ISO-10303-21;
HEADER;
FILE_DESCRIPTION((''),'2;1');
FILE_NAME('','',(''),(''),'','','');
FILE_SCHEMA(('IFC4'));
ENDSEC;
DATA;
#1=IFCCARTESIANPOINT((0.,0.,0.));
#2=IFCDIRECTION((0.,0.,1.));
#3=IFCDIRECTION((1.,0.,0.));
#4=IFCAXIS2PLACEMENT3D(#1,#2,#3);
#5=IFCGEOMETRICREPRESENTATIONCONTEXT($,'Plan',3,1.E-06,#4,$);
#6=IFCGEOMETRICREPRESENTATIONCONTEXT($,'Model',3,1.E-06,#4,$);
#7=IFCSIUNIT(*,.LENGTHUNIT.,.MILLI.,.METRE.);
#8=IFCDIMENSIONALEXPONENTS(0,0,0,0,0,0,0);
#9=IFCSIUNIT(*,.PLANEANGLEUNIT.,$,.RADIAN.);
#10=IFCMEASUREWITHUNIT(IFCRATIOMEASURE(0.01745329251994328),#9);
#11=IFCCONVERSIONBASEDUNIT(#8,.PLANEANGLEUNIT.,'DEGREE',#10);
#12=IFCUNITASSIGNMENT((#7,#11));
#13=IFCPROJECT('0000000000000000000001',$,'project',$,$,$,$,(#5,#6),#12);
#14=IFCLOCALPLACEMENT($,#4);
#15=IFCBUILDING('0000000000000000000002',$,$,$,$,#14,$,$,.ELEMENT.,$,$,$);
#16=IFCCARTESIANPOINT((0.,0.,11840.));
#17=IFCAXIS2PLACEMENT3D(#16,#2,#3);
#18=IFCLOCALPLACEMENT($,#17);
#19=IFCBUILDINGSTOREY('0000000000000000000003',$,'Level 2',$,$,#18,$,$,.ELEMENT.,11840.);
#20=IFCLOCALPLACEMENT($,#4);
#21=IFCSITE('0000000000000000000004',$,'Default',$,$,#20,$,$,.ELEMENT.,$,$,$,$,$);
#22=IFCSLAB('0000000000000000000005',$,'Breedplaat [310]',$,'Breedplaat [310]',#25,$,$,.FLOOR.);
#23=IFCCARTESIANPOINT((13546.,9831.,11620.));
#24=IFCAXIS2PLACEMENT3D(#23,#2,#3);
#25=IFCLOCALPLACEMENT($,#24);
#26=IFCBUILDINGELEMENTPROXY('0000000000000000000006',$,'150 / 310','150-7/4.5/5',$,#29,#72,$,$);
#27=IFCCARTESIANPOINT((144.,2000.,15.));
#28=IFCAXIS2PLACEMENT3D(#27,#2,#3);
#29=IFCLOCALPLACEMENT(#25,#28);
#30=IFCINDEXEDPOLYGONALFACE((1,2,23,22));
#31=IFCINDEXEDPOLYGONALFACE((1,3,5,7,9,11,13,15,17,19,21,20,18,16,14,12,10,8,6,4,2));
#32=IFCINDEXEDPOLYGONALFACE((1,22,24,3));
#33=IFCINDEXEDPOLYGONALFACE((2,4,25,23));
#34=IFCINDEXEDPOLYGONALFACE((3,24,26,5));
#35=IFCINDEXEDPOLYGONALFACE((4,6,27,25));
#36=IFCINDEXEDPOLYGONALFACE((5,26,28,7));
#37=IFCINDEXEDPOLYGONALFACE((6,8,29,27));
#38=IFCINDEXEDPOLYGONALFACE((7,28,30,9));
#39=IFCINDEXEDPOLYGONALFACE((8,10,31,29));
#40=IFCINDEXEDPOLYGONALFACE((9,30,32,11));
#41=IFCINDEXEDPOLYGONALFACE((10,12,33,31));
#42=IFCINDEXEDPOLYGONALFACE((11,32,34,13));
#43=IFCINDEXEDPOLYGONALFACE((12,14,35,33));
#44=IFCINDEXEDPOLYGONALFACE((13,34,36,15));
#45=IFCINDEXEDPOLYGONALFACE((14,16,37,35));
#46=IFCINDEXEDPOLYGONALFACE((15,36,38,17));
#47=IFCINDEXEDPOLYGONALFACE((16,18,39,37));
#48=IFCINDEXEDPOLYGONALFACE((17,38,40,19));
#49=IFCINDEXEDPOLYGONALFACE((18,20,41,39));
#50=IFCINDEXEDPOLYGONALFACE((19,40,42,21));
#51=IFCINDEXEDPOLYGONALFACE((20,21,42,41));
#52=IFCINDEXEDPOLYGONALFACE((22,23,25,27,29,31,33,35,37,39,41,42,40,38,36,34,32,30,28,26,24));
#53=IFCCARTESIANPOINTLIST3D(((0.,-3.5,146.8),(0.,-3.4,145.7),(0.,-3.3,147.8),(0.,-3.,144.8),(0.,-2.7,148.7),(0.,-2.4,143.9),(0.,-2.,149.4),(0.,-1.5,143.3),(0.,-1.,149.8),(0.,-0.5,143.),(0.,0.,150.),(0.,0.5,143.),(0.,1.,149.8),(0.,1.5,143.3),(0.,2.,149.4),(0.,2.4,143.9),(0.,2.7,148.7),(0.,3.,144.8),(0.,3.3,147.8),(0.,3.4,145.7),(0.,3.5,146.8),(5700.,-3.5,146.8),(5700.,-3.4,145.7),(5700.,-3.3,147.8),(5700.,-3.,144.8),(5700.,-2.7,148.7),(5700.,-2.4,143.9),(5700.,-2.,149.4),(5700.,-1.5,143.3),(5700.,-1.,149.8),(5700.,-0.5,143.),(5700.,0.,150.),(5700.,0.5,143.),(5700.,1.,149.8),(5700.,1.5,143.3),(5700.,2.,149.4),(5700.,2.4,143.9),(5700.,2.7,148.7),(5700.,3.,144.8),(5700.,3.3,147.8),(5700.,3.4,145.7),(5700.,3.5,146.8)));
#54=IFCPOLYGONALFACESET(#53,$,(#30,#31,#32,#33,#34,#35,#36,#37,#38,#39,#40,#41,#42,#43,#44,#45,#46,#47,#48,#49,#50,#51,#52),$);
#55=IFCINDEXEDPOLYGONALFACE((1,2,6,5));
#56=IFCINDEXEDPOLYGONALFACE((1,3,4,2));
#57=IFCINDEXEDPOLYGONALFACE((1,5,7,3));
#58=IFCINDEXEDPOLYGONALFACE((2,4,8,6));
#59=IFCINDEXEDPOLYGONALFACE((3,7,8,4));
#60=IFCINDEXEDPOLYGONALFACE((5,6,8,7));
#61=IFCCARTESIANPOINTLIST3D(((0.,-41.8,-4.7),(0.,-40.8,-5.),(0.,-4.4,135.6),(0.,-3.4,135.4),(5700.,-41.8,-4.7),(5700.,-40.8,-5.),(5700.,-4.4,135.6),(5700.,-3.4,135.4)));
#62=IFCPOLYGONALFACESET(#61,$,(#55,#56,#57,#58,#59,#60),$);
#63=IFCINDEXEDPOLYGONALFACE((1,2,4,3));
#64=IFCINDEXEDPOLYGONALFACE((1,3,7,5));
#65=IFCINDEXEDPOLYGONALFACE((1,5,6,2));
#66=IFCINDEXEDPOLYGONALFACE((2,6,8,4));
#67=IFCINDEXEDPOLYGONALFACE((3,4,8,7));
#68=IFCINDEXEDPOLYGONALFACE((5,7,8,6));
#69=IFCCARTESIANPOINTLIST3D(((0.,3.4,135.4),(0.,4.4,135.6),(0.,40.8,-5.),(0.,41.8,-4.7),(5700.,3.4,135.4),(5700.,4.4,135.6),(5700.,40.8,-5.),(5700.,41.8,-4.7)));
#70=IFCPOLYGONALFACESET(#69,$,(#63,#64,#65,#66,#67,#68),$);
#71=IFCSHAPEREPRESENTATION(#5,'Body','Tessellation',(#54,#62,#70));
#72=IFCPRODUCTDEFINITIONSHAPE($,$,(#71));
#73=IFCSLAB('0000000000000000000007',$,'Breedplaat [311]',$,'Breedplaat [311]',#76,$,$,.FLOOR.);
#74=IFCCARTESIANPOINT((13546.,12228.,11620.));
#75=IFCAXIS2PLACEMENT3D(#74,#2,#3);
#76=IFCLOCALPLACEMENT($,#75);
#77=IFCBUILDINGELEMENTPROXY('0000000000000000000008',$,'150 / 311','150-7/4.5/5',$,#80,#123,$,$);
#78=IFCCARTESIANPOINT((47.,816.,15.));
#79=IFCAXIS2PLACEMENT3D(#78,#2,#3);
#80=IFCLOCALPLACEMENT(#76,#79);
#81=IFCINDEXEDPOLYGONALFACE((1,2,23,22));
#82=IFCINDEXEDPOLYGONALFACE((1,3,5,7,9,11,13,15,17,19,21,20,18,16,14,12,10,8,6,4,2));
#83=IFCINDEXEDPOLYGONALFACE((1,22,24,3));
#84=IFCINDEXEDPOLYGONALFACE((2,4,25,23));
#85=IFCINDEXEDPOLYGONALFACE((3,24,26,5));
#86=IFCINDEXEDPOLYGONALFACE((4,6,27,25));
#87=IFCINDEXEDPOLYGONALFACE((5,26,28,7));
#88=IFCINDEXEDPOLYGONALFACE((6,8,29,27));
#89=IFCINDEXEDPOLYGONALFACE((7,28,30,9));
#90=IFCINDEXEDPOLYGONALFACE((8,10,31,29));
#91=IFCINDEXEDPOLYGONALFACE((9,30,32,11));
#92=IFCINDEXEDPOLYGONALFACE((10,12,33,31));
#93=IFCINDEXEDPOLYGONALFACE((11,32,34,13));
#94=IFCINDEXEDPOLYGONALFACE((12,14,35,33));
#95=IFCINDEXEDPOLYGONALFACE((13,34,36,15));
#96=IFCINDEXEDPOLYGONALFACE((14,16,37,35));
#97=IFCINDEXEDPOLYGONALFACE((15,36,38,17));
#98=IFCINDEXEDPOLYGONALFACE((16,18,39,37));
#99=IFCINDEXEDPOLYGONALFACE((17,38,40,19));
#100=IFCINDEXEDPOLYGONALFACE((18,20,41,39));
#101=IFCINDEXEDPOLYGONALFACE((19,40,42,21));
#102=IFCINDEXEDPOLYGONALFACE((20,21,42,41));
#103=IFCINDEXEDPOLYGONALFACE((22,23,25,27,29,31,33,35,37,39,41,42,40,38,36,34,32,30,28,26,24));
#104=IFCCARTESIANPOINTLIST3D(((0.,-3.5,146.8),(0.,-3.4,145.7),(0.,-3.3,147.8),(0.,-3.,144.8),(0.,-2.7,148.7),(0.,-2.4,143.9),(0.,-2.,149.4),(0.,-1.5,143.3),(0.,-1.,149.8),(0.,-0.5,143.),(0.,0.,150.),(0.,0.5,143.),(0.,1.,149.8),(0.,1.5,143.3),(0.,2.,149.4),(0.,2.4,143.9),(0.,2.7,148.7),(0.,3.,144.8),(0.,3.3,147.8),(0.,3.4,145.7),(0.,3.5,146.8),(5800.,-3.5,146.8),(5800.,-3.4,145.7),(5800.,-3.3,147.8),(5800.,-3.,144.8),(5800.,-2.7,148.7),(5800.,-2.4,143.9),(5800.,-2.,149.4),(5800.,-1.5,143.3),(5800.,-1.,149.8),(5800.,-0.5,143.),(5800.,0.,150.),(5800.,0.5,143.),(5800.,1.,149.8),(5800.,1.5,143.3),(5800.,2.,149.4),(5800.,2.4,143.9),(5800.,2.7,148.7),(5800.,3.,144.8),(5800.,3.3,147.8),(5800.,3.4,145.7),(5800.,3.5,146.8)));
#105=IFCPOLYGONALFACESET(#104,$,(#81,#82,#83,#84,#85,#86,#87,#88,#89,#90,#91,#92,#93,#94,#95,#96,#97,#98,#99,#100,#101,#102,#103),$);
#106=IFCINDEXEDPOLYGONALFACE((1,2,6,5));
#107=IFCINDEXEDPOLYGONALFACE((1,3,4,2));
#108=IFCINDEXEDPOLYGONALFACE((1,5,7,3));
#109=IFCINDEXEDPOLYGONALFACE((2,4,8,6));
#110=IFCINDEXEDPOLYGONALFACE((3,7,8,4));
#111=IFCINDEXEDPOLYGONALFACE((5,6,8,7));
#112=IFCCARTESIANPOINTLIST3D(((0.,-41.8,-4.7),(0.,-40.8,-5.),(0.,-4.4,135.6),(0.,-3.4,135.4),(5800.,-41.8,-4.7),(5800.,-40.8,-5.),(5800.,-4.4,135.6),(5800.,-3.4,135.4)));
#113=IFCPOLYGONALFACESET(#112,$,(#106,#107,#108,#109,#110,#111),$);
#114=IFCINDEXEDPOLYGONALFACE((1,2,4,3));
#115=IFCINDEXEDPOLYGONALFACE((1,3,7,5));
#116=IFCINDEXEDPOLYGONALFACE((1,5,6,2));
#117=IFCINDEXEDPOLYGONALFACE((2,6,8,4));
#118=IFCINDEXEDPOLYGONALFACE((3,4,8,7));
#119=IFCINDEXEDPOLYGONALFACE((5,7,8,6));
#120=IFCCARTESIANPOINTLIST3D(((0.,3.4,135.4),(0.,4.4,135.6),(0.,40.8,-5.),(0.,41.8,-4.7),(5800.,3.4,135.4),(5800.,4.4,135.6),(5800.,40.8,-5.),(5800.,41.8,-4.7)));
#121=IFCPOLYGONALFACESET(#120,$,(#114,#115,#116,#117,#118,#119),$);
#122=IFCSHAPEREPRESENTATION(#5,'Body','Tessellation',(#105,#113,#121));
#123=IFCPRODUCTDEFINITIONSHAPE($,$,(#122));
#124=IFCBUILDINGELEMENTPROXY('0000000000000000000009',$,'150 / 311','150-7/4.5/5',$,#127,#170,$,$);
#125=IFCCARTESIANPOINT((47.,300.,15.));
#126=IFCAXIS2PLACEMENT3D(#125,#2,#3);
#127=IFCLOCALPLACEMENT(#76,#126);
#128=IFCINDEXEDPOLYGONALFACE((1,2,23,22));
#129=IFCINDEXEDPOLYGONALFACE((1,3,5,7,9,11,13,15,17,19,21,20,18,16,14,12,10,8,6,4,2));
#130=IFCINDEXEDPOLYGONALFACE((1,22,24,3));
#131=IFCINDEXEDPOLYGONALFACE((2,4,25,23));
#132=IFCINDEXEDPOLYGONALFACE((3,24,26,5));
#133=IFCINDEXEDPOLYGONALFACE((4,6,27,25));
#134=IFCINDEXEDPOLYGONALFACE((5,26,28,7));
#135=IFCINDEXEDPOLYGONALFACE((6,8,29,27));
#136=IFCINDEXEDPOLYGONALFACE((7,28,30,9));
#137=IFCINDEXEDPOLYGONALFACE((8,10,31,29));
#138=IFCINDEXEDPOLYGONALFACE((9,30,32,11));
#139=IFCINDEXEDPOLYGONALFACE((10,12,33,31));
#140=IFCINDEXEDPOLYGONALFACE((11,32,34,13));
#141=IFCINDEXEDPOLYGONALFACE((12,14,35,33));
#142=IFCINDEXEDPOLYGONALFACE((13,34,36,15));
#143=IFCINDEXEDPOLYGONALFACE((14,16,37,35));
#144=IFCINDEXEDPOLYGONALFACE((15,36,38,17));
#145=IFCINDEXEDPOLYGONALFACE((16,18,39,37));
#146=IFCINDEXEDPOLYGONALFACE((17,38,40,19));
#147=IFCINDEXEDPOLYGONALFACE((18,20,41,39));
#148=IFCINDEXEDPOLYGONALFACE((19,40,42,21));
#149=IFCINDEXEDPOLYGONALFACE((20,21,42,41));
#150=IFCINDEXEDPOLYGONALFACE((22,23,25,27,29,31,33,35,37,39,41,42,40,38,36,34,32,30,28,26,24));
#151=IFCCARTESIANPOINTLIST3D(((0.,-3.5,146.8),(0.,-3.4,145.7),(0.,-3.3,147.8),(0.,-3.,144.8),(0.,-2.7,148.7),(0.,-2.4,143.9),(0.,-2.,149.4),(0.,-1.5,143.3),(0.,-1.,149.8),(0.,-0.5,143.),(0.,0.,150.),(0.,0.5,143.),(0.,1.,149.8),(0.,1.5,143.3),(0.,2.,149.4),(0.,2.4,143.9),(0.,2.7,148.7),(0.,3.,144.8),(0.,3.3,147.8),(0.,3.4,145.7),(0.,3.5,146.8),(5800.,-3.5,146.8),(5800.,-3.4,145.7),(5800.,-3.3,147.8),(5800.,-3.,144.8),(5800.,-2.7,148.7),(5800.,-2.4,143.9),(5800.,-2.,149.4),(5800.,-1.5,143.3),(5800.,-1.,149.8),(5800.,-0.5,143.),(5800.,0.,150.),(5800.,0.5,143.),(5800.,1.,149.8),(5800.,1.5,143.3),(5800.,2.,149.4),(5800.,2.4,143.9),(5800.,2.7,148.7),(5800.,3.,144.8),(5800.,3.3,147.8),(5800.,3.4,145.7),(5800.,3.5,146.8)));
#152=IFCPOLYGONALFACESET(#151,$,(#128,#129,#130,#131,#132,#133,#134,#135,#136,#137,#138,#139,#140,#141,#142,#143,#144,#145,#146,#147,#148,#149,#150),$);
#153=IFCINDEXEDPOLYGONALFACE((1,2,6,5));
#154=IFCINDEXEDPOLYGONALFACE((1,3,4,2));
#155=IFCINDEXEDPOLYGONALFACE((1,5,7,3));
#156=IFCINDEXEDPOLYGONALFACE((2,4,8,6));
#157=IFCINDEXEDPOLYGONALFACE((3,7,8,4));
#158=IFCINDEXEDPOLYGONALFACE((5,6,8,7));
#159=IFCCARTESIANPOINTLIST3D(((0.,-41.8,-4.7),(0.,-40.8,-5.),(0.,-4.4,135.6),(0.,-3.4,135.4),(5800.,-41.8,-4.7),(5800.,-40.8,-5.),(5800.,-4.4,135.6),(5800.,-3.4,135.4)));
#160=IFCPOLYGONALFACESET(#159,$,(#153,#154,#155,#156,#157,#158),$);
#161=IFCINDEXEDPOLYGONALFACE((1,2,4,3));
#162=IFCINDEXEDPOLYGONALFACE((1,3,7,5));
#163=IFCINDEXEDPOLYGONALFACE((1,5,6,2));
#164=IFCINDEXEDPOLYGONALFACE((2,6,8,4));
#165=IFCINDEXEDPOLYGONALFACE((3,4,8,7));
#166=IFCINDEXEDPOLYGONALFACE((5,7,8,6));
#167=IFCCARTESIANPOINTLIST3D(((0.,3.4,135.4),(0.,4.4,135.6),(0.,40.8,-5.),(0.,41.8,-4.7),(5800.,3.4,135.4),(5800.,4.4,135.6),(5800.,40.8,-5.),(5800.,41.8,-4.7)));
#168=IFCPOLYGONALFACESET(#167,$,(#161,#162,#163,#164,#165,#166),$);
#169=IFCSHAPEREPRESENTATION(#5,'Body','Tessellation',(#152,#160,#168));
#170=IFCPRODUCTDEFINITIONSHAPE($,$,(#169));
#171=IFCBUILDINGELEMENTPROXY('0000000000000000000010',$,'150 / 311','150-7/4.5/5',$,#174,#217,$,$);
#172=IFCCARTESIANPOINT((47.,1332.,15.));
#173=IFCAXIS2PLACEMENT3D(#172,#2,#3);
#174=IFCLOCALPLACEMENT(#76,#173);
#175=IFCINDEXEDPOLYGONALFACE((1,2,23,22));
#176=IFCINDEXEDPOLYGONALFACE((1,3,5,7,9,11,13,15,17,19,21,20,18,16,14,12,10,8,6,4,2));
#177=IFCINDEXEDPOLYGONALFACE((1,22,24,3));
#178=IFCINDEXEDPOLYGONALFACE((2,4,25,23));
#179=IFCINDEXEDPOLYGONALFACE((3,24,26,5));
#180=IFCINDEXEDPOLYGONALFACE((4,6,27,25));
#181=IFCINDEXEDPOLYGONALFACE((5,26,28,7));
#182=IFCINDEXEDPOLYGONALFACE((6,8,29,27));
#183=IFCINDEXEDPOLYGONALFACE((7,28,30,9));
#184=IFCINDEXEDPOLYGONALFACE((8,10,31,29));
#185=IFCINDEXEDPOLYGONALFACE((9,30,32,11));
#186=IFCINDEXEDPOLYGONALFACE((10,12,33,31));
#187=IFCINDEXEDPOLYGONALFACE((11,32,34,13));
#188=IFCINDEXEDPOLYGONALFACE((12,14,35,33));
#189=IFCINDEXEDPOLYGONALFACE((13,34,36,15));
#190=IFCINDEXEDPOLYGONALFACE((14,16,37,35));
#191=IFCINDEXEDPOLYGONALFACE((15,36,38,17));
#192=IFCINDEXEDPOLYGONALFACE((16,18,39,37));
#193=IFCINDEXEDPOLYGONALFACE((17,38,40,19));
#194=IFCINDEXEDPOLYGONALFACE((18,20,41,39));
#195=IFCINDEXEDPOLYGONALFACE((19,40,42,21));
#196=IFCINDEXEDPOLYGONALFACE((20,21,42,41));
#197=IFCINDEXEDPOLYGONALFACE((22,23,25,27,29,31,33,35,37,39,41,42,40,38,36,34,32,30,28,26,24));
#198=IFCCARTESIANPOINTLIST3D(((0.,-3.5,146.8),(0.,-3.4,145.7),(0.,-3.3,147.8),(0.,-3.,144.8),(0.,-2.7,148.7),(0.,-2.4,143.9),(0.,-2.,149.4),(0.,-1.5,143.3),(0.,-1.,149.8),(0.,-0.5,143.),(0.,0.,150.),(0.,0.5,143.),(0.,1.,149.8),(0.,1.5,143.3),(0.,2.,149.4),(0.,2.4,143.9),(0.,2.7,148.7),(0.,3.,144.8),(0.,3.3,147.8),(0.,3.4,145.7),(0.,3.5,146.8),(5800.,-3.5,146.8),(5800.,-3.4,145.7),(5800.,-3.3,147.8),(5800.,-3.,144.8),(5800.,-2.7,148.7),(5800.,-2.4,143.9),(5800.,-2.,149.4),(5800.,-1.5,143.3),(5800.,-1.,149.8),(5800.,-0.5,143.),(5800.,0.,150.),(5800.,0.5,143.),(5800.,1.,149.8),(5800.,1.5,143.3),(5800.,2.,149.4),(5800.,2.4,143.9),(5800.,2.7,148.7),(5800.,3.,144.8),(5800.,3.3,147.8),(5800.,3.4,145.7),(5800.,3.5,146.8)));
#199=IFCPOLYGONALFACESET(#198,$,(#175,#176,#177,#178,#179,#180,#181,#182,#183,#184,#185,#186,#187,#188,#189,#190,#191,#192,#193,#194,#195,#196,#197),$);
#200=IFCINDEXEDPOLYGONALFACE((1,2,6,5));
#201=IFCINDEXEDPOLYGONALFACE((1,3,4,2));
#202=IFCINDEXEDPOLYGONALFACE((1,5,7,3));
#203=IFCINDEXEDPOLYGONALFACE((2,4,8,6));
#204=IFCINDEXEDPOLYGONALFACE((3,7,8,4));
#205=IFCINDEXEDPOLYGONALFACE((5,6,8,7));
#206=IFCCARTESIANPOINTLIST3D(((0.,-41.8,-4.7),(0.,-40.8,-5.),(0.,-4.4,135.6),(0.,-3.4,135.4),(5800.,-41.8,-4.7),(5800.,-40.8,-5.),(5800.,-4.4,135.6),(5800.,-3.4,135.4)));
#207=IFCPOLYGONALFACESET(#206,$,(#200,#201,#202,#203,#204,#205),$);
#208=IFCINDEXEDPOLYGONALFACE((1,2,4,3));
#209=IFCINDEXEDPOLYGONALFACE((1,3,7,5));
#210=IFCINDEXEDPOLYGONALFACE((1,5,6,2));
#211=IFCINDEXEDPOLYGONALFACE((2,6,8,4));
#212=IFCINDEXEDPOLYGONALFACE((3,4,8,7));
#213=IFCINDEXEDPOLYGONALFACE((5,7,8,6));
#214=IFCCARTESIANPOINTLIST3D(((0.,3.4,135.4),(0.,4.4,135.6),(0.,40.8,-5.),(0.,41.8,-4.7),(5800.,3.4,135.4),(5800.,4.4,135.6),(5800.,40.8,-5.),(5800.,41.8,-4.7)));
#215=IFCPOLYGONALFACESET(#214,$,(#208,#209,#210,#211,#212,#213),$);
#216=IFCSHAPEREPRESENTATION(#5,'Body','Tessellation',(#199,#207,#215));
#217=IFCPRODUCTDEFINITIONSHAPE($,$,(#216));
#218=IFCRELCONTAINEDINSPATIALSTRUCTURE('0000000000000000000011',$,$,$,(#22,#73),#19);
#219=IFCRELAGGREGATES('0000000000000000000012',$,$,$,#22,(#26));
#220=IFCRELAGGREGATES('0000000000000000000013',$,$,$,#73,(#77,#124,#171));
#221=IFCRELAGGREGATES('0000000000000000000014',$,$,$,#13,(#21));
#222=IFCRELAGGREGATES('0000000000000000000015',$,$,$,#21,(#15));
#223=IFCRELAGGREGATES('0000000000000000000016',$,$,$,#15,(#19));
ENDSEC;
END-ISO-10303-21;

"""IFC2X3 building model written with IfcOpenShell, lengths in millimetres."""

from ifc_helpers import new_model, entity, si_unit, converted_unit, frame, origin_with_axes, origin_2d_with_axis, place, context, project, spatial, rectangle, circle, extrude, element, aggregate, save


model = new_model("IFC2X3")

# Units and contexts
plan_context = context("Plan", 3, precision=1e-06, world=origin_with_axes())
model_context = context("Model", 3, precision=1e-06, world=origin_with_axes())
ifc_project = project(units=[si_unit("LENGTHUNIT", "METRE", prefix="MILLI"), converted_unit("PLANEANGLEUNIT", "DEGREE", entity("IfcRatioMeasure", 0.01745329251994328), si_unit("PLANEANGLEUNIT", "RADIAN"), dimensions=[0, 0, 0, 0, 0, 0, 0])], contexts=[plan_context, model_context])

# Site, building, storey
site_placement = place(None, origin_with_axes())
site = spatial("IfcSite", under=ifc_project, at=site_placement, Name="Default", CompositionType="ELEMENT")
building_placement = place(None, origin_with_axes())
building = spatial("IfcBuilding", under=site, at=building_placement, CompositionType="ELEMENT")
storey_placement = place(None, frame((0.0, 0.0, 11840.0), z_axis=(0.0, 0.0, 1.0), x_axis=(1.0, 0.0, 0.0)))
storey = spatial("IfcBuildingStorey", under=building, at=storey_placement, Name="Level 2", CompositionType="ELEMENT", Elevation=11840.0)

# Slab, building element proxy
slab_1_placement = place(None, frame((13546.0, 9831.0, 11620.0), z_axis=(0.0, 0.0, 1.0), x_axis=(1.0, 0.0, 0.0)))
slab_1 = element("IfcSlab", 1, at=slab_1_placement, inside=storey, Name="Breedplaat [310]", ObjectType="Breedplaat [310]", PredefinedType="FLOOR")
proxy_1_placement = place(slab_1_placement, frame((144.0, 2000.0, 15.0), z_axis=(0.0, 0.0, 1.0), x_axis=(1.0, 0.0, 0.0)))
proxy_1 = element("IfcBuildingElementProxy", 2, at=proxy_1_placement, Name="150 / 310", Description="150-7/4.5/5", context=plan_context, shape_type="SweptSolid", body=[
    extrude(circle(Radius=3.5, at=origin_2d_with_axis()), frame((0.0, 0.0, 146.5), z_axis=(1.0, 0.0, 0.0), x_axis=(0.0, 0.0, 1.0)), (0.0, 0.0, 1.0), 5700.0),
    extrude(rectangle(XDim=145.2, YDim=1.0, at=origin_2d_with_axis()), frame((0.0, -22.6, 65.3), z_axis=(1.0, 0.0, 0.0), x_axis=(0.0, 0.257663, 0.966235)), (0.0, 0.0, 1.0), 5700.0),
    extrude(rectangle(XDim=145.2, YDim=1.0, at=origin_2d_with_axis()), frame((0.0, 22.6, 65.3), z_axis=(1.0, 0.0, 0.0), x_axis=(0.0, -0.257663, 0.966235)), (0.0, 0.0, 1.0), 5700.0),
])
aggregate(slab_1, [proxy_1])

# Slab, building element proxies
slab_2_placement = place(None, frame((13546.0, 12228.0, 11620.0), z_axis=(0.0, 0.0, 1.0), x_axis=(1.0, 0.0, 0.0)))
slab_2 = element("IfcSlab", 3, at=slab_2_placement, inside=storey, Name="Breedplaat [311]", ObjectType="Breedplaat [311]", PredefinedType="FLOOR")
proxy_2_placement = place(slab_2_placement, frame((47.0, 816.0, 15.0), z_axis=(0.0, 0.0, 1.0), x_axis=(1.0, 0.0, 0.0)))
proxy_2 = element("IfcBuildingElementProxy", 4, at=proxy_2_placement, Name="150 / 311", Description="150-7/4.5/5", context=plan_context, shape_type="SweptSolid", body=[
    extrude(circle(Radius=3.5, at=origin_2d_with_axis()), frame((0.0, 0.0, 146.5), z_axis=(1.0, 0.0, 0.0), x_axis=(0.0, 0.0, 1.0)), (0.0, 0.0, 1.0), 5800.0),
    extrude(rectangle(XDim=145.2, YDim=1.0, at=origin_2d_with_axis()), frame((0.0, -22.6, 65.3), z_axis=(1.0, 0.0, 0.0), x_axis=(0.0, 0.257663, 0.966235)), (0.0, 0.0, 1.0), 5800.0),
    extrude(rectangle(XDim=145.2, YDim=1.0, at=origin_2d_with_axis()), frame((0.0, 22.6, 65.3), z_axis=(1.0, 0.0, 0.0), x_axis=(0.0, -0.257663, 0.966235)), (0.0, 0.0, 1.0), 5800.0),
])
proxy_3_placement = place(slab_2_placement, frame((47.0, 300.0, 15.0), z_axis=(0.0, 0.0, 1.0), x_axis=(1.0, 0.0, 0.0)))
proxy_3 = element("IfcBuildingElementProxy", 5, at=proxy_3_placement, Name="150 / 311", Description="150-7/4.5/5", context=plan_context, shape_type="SweptSolid", body=[
    extrude(circle(Radius=3.5, at=origin_2d_with_axis()), frame((0.0, 0.0, 146.5), z_axis=(1.0, 0.0, 0.0), x_axis=(0.0, 0.0, 1.0)), (0.0, 0.0, 1.0), 5800.0),
    extrude(rectangle(XDim=145.2, YDim=1.0, at=origin_2d_with_axis()), frame((0.0, -22.6, 65.3), z_axis=(1.0, 0.0, 0.0), x_axis=(0.0, 0.257663, 0.966235)), (0.0, 0.0, 1.0), 5800.0),
    extrude(rectangle(XDim=145.2, YDim=1.0, at=origin_2d_with_axis()), frame((0.0, 22.6, 65.3), z_axis=(1.0, 0.0, 0.0), x_axis=(0.0, -0.257663, 0.966235)), (0.0, 0.0, 1.0), 5800.0),
])
proxy_4_placement = place(slab_2_placement, frame((47.0, 1332.0, 15.0), z_axis=(0.0, 0.0, 1.0), x_axis=(1.0, 0.0, 0.0)))
proxy_4 = element("IfcBuildingElementProxy", 6, at=proxy_4_placement, Name="150 / 311", Description="150-7/4.5/5", context=plan_context, shape_type="SweptSolid", body=[
    extrude(circle(Radius=3.5, at=origin_2d_with_axis()), frame((0.0, 0.0, 146.5), z_axis=(1.0, 0.0, 0.0), x_axis=(0.0, 0.0, 1.0)), (0.0, 0.0, 1.0), 5800.0),
    extrude(rectangle(XDim=145.2, YDim=1.0, at=origin_2d_with_axis()), frame((0.0, -22.6, 65.3), z_axis=(1.0, 0.0, 0.0), x_axis=(0.0, 0.257663, 0.966235)), (0.0, 0.0, 1.0), 5800.0),
    extrude(rectangle(XDim=145.2, YDim=1.0, at=origin_2d_with_axis()), frame((0.0, 22.6, 65.3), z_axis=(1.0, 0.0, 0.0), x_axis=(0.0, -0.257663, 0.966235)), (0.0, 0.0, 1.0), 5800.0),
])
aggregate(slab_2, [proxy_2, proxy_3, proxy_4])

save(model, "model.ifc")
